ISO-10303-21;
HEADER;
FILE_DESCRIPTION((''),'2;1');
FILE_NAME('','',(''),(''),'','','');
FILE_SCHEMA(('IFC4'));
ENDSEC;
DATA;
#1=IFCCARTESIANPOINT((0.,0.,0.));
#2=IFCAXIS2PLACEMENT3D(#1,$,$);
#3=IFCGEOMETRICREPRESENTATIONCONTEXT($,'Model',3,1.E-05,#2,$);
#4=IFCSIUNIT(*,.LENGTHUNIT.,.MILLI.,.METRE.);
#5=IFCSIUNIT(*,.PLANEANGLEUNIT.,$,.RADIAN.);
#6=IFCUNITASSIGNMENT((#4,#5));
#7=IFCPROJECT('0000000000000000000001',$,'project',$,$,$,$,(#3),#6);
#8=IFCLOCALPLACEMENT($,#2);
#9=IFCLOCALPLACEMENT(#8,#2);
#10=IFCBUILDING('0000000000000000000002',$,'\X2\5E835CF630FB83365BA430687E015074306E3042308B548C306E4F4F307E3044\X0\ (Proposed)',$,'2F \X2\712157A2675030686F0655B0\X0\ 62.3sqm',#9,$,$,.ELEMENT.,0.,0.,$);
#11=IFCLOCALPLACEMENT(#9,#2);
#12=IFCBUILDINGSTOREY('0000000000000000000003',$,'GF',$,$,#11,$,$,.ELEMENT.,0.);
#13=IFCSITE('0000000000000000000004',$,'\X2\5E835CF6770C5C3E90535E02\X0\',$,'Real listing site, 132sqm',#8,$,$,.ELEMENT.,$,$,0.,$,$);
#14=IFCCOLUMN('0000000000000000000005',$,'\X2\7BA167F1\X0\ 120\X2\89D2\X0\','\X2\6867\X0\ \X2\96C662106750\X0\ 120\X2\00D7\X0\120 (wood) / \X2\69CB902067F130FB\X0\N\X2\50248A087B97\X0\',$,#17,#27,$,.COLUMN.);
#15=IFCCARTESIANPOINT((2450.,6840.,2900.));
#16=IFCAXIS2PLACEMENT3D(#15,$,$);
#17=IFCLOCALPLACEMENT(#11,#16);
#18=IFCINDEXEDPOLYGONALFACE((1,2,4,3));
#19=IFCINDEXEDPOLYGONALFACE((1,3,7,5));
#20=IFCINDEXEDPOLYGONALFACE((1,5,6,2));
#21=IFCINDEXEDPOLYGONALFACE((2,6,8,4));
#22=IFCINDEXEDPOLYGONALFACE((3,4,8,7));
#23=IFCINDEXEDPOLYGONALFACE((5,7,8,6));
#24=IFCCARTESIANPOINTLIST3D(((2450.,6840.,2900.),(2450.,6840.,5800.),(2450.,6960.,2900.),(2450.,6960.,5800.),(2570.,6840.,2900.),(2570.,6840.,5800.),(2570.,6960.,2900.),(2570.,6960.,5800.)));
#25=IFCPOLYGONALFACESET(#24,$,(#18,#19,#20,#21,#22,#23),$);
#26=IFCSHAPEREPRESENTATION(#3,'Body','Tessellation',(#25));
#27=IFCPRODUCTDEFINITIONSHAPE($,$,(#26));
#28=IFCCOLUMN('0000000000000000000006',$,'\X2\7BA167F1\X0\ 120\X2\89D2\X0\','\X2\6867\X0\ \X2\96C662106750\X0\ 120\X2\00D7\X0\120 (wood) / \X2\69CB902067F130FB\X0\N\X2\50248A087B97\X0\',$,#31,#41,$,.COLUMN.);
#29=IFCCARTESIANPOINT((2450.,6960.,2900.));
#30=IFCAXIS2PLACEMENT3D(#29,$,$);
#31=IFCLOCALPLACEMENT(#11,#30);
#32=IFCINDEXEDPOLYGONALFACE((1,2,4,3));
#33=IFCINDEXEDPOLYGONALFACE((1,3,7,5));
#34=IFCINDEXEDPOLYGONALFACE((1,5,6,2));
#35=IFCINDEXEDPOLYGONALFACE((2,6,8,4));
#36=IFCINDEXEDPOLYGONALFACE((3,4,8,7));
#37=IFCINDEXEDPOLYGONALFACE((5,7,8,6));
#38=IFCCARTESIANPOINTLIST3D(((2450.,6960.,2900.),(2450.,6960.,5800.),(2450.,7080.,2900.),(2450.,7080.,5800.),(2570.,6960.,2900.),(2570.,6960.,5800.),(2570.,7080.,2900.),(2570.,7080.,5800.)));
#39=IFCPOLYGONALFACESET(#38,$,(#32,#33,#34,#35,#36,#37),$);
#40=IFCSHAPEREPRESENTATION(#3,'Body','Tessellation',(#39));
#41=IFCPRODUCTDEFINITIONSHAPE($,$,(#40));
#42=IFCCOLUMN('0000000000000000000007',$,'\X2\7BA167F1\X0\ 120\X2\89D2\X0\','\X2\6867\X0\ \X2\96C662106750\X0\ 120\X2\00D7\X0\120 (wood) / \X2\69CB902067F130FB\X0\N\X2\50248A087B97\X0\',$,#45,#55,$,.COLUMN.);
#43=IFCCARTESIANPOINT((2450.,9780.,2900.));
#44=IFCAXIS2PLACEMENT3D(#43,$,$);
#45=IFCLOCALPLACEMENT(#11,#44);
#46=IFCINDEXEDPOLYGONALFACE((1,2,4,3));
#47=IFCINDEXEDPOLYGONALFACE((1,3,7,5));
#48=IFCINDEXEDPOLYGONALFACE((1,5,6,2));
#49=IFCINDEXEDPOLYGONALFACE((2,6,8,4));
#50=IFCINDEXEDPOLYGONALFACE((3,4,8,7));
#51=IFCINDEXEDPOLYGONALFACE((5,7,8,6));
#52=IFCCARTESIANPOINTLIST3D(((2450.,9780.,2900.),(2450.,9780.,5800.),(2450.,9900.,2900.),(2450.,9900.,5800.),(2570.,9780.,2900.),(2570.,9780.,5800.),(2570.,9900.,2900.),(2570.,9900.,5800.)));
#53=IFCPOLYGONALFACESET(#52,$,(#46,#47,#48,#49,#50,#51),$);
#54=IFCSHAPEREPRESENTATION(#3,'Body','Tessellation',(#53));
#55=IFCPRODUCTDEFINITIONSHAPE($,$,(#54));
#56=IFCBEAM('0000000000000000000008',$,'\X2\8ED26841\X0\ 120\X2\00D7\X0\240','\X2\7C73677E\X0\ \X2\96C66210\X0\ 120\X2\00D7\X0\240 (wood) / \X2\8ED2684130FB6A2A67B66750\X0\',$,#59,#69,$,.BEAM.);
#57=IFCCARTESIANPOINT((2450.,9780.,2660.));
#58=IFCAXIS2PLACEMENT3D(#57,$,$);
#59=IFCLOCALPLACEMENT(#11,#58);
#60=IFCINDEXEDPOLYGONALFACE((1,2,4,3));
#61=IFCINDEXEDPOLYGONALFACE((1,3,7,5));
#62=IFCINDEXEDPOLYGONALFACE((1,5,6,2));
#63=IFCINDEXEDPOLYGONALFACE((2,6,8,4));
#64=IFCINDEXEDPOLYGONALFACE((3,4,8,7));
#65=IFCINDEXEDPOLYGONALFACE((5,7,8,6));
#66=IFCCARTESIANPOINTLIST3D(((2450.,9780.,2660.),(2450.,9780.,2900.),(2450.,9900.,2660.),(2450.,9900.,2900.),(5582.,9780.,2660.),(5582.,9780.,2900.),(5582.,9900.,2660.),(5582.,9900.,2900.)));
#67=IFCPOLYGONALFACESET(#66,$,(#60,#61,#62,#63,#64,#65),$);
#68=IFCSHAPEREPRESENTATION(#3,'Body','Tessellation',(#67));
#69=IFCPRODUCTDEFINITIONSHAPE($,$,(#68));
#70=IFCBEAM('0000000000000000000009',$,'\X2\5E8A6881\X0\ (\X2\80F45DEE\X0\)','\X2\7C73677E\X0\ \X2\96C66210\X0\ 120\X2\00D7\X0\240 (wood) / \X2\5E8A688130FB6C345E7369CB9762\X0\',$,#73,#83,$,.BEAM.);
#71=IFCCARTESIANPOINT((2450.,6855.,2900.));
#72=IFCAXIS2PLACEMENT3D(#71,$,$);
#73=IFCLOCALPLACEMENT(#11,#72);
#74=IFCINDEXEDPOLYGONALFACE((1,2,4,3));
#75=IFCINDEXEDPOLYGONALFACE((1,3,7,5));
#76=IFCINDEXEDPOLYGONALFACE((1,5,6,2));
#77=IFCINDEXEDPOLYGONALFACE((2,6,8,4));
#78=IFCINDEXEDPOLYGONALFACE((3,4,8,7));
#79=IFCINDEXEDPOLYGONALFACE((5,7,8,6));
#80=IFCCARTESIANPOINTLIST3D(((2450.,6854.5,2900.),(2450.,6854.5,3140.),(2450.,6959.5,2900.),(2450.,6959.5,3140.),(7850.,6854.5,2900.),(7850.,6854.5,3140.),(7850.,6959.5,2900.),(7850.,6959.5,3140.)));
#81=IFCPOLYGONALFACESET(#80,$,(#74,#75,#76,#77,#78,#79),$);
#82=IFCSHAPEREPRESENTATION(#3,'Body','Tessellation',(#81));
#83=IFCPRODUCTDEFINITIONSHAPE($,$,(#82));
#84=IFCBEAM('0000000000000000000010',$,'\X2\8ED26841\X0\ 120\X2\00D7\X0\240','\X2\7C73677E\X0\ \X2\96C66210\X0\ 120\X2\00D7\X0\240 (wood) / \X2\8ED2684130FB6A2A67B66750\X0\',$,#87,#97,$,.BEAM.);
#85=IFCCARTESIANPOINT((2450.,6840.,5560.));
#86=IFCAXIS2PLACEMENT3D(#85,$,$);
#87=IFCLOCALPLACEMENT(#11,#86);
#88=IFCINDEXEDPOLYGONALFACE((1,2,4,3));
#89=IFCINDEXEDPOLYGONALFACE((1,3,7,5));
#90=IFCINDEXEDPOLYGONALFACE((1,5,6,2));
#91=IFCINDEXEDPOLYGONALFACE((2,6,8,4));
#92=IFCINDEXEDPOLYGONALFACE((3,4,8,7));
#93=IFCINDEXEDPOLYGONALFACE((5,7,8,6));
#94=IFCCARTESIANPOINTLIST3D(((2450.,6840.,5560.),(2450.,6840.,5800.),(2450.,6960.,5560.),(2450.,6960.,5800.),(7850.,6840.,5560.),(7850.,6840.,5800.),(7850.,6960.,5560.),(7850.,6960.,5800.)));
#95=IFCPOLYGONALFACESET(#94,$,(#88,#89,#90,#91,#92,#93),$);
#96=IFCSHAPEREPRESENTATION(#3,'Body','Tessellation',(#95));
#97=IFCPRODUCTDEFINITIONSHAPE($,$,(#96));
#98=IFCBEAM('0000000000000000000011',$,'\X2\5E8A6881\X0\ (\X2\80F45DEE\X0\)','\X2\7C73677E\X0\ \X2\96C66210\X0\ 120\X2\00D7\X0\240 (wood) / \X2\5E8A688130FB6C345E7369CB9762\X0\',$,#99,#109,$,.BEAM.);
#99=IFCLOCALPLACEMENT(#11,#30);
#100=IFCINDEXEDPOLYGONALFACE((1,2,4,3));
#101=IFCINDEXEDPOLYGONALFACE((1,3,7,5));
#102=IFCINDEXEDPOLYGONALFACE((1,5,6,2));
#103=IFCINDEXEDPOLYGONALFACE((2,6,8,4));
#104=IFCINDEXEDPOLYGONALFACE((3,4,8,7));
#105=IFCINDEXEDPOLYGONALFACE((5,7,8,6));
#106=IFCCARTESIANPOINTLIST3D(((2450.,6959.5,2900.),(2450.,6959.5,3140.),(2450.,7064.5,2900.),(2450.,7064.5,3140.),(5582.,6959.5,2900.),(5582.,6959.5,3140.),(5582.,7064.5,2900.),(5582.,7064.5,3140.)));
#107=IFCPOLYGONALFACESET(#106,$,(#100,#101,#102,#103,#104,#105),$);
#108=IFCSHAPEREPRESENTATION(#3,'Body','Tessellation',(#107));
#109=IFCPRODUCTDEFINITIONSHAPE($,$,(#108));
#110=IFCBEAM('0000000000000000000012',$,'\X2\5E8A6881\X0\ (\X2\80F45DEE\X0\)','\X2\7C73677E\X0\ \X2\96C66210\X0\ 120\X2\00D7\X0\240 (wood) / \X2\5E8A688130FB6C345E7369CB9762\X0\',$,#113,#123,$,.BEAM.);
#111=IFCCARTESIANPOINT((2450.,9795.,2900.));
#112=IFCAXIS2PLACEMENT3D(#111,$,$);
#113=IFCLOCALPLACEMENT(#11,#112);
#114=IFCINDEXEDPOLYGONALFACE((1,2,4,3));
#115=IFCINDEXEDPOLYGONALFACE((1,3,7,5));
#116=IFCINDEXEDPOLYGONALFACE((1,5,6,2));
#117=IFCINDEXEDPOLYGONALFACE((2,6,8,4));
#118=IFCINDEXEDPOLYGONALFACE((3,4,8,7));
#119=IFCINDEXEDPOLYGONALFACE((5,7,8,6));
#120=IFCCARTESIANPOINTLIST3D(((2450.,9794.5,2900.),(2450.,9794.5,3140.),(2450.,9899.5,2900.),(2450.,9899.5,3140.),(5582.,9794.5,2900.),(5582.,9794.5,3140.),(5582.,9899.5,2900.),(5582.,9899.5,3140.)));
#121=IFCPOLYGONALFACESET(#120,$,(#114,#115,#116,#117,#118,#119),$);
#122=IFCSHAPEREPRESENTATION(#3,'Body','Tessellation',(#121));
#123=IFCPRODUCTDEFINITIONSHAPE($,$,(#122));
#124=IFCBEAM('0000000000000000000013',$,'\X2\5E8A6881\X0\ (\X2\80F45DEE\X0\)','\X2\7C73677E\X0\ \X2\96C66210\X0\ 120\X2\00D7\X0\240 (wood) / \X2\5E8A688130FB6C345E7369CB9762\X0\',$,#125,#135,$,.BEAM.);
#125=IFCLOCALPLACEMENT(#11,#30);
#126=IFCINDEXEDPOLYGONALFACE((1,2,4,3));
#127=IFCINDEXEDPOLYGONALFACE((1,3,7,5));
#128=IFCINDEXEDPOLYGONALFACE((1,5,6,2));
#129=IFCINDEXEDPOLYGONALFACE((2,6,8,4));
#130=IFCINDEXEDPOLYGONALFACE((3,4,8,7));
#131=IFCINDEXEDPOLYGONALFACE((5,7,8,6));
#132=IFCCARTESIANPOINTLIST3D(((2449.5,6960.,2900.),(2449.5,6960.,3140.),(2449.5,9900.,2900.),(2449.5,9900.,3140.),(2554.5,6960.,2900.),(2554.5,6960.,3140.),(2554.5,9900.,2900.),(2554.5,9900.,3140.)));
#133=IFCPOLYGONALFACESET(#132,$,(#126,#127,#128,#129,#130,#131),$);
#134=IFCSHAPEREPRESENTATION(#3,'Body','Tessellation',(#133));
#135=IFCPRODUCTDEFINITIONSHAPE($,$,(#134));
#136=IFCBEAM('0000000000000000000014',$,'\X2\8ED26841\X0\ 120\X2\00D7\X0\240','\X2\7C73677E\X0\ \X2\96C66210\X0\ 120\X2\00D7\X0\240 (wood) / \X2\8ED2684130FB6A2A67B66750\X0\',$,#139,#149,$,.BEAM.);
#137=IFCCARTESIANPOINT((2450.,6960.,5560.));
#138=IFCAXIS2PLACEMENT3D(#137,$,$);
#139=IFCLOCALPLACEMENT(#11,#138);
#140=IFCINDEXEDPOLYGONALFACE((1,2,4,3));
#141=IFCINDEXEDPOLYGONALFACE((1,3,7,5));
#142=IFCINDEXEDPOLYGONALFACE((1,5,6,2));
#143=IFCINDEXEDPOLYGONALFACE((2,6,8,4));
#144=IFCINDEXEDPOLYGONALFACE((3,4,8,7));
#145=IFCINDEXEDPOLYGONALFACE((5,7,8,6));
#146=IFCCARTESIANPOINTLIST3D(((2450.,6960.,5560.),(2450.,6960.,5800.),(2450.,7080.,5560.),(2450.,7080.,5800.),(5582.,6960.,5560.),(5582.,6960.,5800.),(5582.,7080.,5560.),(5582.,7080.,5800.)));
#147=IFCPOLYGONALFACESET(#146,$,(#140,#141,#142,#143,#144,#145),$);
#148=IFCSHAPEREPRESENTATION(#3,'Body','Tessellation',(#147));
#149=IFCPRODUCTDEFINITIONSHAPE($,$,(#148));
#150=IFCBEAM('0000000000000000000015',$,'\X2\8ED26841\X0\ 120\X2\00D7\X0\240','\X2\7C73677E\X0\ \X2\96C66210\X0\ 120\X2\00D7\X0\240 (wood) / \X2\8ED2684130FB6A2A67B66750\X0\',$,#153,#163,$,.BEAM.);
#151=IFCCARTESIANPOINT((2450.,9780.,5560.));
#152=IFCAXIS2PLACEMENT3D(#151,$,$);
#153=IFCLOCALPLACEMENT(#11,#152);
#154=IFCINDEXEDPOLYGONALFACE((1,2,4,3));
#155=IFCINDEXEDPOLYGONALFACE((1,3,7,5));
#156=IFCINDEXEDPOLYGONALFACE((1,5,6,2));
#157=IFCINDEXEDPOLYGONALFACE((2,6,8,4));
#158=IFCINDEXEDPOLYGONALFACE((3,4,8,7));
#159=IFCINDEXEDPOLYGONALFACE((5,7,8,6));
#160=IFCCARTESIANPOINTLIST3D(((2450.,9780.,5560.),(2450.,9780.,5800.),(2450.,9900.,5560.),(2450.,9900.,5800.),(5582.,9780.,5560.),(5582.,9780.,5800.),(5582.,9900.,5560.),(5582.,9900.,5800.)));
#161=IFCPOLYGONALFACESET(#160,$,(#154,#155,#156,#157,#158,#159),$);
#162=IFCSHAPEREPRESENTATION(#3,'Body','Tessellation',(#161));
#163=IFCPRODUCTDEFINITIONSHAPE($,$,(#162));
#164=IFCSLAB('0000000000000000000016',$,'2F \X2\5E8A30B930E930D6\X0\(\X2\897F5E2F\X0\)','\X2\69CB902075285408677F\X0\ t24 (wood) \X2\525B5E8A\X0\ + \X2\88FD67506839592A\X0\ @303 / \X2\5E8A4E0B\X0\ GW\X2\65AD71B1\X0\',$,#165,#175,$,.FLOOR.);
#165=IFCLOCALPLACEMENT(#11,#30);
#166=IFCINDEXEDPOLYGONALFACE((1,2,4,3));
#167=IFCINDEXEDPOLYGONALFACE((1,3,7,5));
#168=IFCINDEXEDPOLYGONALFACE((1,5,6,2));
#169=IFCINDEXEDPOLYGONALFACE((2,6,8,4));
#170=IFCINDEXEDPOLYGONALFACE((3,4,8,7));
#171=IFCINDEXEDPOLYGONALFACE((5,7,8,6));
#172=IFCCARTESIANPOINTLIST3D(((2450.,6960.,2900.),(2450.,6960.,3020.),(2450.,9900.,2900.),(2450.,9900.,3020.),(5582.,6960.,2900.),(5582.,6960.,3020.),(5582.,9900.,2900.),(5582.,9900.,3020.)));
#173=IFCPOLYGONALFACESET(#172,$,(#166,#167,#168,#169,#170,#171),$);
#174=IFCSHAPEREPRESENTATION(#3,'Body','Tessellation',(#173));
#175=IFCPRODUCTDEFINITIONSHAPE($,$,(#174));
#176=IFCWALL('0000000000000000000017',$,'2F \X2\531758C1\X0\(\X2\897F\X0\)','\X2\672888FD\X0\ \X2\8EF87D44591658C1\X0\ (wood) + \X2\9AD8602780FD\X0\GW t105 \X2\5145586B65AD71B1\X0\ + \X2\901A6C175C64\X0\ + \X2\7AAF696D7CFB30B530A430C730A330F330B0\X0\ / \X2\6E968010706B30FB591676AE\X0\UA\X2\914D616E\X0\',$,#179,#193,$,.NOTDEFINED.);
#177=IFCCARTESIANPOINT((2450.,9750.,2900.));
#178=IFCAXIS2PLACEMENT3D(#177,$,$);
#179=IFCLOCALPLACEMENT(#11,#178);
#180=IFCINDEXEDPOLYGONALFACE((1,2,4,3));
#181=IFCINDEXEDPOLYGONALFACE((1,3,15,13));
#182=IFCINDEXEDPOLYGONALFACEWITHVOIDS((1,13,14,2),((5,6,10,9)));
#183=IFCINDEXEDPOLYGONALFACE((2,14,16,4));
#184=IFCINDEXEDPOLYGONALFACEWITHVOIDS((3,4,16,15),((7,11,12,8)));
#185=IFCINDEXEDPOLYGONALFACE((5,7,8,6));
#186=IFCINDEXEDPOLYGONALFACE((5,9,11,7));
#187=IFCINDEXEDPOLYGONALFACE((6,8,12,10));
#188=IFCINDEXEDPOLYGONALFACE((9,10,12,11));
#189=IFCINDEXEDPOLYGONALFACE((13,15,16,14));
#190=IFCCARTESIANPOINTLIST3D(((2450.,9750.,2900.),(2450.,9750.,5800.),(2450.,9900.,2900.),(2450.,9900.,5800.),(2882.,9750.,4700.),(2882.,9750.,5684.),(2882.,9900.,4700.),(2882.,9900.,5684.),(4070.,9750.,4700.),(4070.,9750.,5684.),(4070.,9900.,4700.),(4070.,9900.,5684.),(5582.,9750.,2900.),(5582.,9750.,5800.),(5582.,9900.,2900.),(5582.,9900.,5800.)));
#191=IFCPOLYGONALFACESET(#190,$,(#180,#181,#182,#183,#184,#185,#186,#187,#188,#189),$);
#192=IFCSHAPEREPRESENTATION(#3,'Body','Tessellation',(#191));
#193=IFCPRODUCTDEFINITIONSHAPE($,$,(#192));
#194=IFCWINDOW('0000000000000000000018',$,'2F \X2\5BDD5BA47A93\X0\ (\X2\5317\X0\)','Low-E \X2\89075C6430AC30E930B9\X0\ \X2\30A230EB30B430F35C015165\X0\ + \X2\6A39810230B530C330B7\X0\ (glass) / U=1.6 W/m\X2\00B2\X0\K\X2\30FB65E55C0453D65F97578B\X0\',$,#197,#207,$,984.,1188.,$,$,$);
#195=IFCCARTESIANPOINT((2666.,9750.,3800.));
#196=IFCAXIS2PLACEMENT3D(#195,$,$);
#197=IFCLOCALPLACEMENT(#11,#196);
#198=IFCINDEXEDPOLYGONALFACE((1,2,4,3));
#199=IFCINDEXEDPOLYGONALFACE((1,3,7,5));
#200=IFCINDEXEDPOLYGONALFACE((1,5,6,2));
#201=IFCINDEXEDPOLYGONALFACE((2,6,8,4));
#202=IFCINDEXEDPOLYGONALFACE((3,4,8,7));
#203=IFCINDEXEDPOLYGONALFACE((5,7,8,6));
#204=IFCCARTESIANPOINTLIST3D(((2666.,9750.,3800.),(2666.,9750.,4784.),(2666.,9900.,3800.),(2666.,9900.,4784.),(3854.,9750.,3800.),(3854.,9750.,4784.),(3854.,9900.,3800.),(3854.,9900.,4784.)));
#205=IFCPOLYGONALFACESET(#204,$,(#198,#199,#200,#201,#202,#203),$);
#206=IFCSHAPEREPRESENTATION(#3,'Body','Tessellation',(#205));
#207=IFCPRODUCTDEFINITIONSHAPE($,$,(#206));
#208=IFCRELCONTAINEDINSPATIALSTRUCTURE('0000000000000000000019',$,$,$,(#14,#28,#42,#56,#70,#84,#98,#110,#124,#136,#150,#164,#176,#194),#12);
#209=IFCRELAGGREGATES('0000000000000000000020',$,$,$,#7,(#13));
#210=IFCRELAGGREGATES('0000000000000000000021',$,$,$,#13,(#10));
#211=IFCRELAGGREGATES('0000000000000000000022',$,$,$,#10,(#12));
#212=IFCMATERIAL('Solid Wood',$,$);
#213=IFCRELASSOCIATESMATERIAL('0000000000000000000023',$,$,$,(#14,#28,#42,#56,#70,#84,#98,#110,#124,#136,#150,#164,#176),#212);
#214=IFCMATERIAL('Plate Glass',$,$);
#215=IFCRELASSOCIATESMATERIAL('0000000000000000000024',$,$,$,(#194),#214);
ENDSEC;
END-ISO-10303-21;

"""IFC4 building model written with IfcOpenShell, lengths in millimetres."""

from ifc_helpers import new_model, si_unit, frame, frame_2d, origin, place, context, project, spatial, rectangle, extrude, material, element, fill, save


model = new_model("IFC4")

# Units and contexts
model_context = context("Model", 3, precision=1e-05, world=origin())
ifc_project = project(units=[si_unit("LENGTHUNIT", "METRE", prefix="MILLI"), si_unit("PLANEANGLEUNIT", "RADIAN")], contexts=[model_context])

# Site, building, storey
site_placement = place(None, origin())
site = spatial("IfcSite", under=ifc_project, at=site_placement, Name="広島県尾道市", ObjectType="Real listing site, 132sqm", CompositionType="ELEMENT", RefElevation=0.0)
building_placement = place(site_placement, origin())
building = spatial("IfcBuilding", under=site, at=building_placement, Name="広島・茶室と縁側のある和の住まい (Proposed)", ObjectType="2F 無垢材と漆喰 62.3sqm", CompositionType="ELEMENT", ElevationOfRefHeight=0.0, ElevationOfTerrain=0.0)
storey_placement = place(building_placement, origin())
storey = spatial("IfcBuildingStorey", under=building, at=storey_placement, Name="GF", CompositionType="ELEMENT", Elevation=0.0)

# Columns
ifc_material_1 = material(Name="Solid Wood")
column_1_placement = place(storey_placement, frame((2450.0, 6840.0, 2900.0)))
element("IfcColumn", 1, at=column_1_placement, inside=storey, material=ifc_material_1, Name="管柱 120角", Description="桧 集成材 120×120 (wood) / 構造柱・N値計算", PredefinedType="COLUMN", context=model_context, shape_type="SweptSolid", body=[
    extrude(rectangle(XDim=120.0, YDim=120.0, at=frame_2d((60.0, 60.0))), frame((2450.0, 6840.0, 2900.0)), (0.0, 0.0, 1.0), 2900.0),
])
column_2_placement = place(storey_placement, frame((2450.0, 6960.0, 2900.0)))
element("IfcColumn", 2, at=column_2_placement, inside=storey, material=ifc_material_1, Name="管柱 120角", Description="桧 集成材 120×120 (wood) / 構造柱・N値計算", PredefinedType="COLUMN", context=model_context, shape_type="SweptSolid", body=[
    extrude(rectangle(XDim=120.0, YDim=120.0, at=frame_2d((60.0, 60.0))), frame((2450.0, 6960.0, 2900.0)), (0.0, 0.0, 1.0), 2900.0),
])
column_3_placement = place(storey_placement, frame((2450.0, 9780.0, 2900.0)))
element("IfcColumn", 3, at=column_3_placement, inside=storey, material=ifc_material_1, Name="管柱 120角", Description="桧 集成材 120×120 (wood) / 構造柱・N値計算", PredefinedType="COLUMN", context=model_context, shape_type="SweptSolid", body=[
    extrude(rectangle(XDim=120.0, YDim=120.0, at=frame_2d((60.0, 60.0))), frame((2450.0, 9780.0, 2900.0)), (0.0, 0.0, 1.0), 2900.0),
])

# Beams
beam_1_placement = place(storey_placement, frame((2450.0, 9780.0, 2660.0)))
element("IfcBeam", 4, at=beam_1_placement, inside=storey, material=ifc_material_1, Name="軒桁 120×240", Description="米松 集成 120×240 (wood) / 軒桁・横架材", PredefinedType="BEAM", context=model_context, shape_type="SweptSolid", body=[
    extrude(rectangle(XDim=3132.0, YDim=120.0, at=frame_2d((1566.0, 60.0))), frame((2450.0, 9780.0, 2660.0)), (0.0, 0.0, 1.0), 240.0),
])
beam_2_placement = place(storey_placement, frame((2450.0, 6855.0, 2900.0)))
element("IfcBeam", 5, at=beam_2_placement, inside=storey, material=ifc_material_1, Name="床梁 (胴差)", Description="米松 集成 120×240 (wood) / 床梁・水平構面", PredefinedType="BEAM", context=model_context, shape_type="SweptSolid", body=[
    extrude(rectangle(XDim=5400.0, YDim=105.0, at=frame_2d((2700.0, 52.0))), frame((2450.0, 6855.0, 2900.0)), (0.0, 0.0, 1.0), 240.0),
])
beam_3_placement = place(storey_placement, frame((2450.0, 6840.0, 5560.0)))
element("IfcBeam", 6, at=beam_3_placement, inside=storey, material=ifc_material_1, Name="軒桁 120×240", Description="米松 集成 120×240 (wood) / 軒桁・横架材", PredefinedType="BEAM", context=model_context, shape_type="SweptSolid", body=[
    extrude(rectangle(XDim=5400.0, YDim=120.0, at=frame_2d((2700.0, 60.0))), frame((2450.0, 6840.0, 5560.0)), (0.0, 0.0, 1.0), 240.0),
])
beam_4_placement = place(storey_placement, frame((2450.0, 6960.0, 2900.0)))
element("IfcBeam", 7, at=beam_4_placement, inside=storey, material=ifc_material_1, Name="床梁 (胴差)", Description="米松 集成 120×240 (wood) / 床梁・水平構面", PredefinedType="BEAM", context=model_context, shape_type="SweptSolid", body=[
    extrude(rectangle(XDim=3132.0, YDim=105.0, at=frame_2d((1566.0, 52.0))), frame((2450.0, 6960.0, 2900.0)), (0.0, 0.0, 1.0), 240.0),
])
beam_5_placement = place(storey_placement, frame((2450.0, 9795.0, 2900.0)))
element("IfcBeam", 8, at=beam_5_placement, inside=storey, material=ifc_material_1, Name="床梁 (胴差)", Description="米松 集成 120×240 (wood) / 床梁・水平構面", PredefinedType="BEAM", context=model_context, shape_type="SweptSolid", body=[
    extrude(rectangle(XDim=3132.0, YDim=105.0, at=frame_2d((1566.0, 52.0))), frame((2450.0, 9795.0, 2900.0)), (0.0, 0.0, 1.0), 240.0),
])
beam_6_placement = place(storey_placement, frame((2450.0, 6960.0, 2900.0)))
element("IfcBeam", 9, at=beam_6_placement, inside=storey, material=ifc_material_1, Name="床梁 (胴差)", Description="米松 集成 120×240 (wood) / 床梁・水平構面", PredefinedType="BEAM", context=model_context, shape_type="SweptSolid", body=[
    extrude(rectangle(XDim=105.0, YDim=2940.0, at=frame_2d((52.0, 1470.0))), frame((2450.0, 6960.0, 2900.0)), (0.0, 0.0, 1.0), 240.0),
])
beam_7_placement = place(storey_placement, frame((2450.0, 6960.0, 5560.0)))
element("IfcBeam", 10, at=beam_7_placement, inside=storey, material=ifc_material_1, Name="軒桁 120×240", Description="米松 集成 120×240 (wood) / 軒桁・横架材", PredefinedType="BEAM", context=model_context, shape_type="SweptSolid", body=[
    extrude(rectangle(XDim=3132.0, YDim=120.0, at=frame_2d((1566.0, 60.0))), frame((2450.0, 6960.0, 5560.0)), (0.0, 0.0, 1.0), 240.0),
])
beam_8_placement = place(storey_placement, frame((2450.0, 9780.0, 5560.0)))
element("IfcBeam", 11, at=beam_8_placement, inside=storey, material=ifc_material_1, Name="軒桁 120×240", Description="米松 集成 120×240 (wood) / 軒桁・横架材", PredefinedType="BEAM", context=model_context, shape_type="SweptSolid", body=[
    extrude(rectangle(XDim=3132.0, YDim=120.0, at=frame_2d((1566.0, 60.0))), frame((2450.0, 9780.0, 5560.0)), (0.0, 0.0, 1.0), 240.0),
])

# Slab
slab_placement = place(storey_placement, frame((2450.0, 6960.0, 2900.0)))
element("IfcSlab", 12, at=slab_placement, inside=storey, material=ifc_material_1, Name="2F 床スラブ(西帯)", Description="構造用合板 t24 (wood) 剛床 + 製材根太 @303 / 床下 GW断熱", PredefinedType="FLOOR", context=model_context, shape_type="SweptSolid", body=[
    extrude(rectangle(XDim=3132.0, YDim=2940.0, at=frame_2d((1566.0, 1470.0))), frame((2450.0, 6960.0, 2900.0)), (0.0, 0.0, 1.0), 120.0),
])

# Wall, opening, window
wall_1_placement = place(storey_placement, frame((2450.0, 9750.0, 2900.0)))
wall_1 = element("IfcWall", 13, at=wall_1_placement, inside=storey, material=ifc_material_1, Name="2F 北壁(西)", Description="木製 軸組外壁 (wood) + 高性能GW t105 充填断熱 + 通気層 + 窯業系サイディング / 準耐火・外皮UA配慮", PredefinedType="NOTDEFINED", context=model_context, shape_type="SweptSolid", body=[
    extrude(rectangle(XDim=3132.0, YDim=150.0, at=frame_2d((1566.0, 75.0))), frame((2450.0, 9750.0, 2900.0)), (0.0, 0.0, 1.0), 2900.0),
])
opening_placement = place(storey_placement, frame((2666.0, 9750.0, 3800.0)))
opening = element("IfcOpeningElement", 14, at=opening_placement, cuts=wall_1, PredefinedType="NOTDEFINED", context=model_context, shape_type="SweptSolid", body=[
    extrude(rectangle(XDim=1188.0, YDim=150.0, at=frame_2d((594.0, 75.0))), frame((2666.0, 9750.0, 3800.0)), (0.0, 0.0, 1.0), 984.0),
])
ifc_material_2 = material(Name="Plate Glass")
window_placement = place(storey_placement, frame((2666.0, 9750.0, 3800.0)))
window = element("IfcWindow", 15, at=window_placement, inside=storey, material=ifc_material_2, Name="2F 寝室窓 (北)", Description="Low-E 複層ガラス アルゴン封入 + 樹脂サッシ (glass) / U=1.6 W/m²K・日射取得型", OverallHeight=984.0, OverallWidth=1188.0, context=model_context, shape_type="SweptSolid", body=[
    extrude(rectangle(XDim=1188.0, YDim=150.0, at=frame_2d((594.0, 75.0))), frame((2666.0, 9750.0, 3800.0)), (0.0, 0.0, 1.0), 984.0),
])
fill(opening, window)

save(model, "model.ifc")
